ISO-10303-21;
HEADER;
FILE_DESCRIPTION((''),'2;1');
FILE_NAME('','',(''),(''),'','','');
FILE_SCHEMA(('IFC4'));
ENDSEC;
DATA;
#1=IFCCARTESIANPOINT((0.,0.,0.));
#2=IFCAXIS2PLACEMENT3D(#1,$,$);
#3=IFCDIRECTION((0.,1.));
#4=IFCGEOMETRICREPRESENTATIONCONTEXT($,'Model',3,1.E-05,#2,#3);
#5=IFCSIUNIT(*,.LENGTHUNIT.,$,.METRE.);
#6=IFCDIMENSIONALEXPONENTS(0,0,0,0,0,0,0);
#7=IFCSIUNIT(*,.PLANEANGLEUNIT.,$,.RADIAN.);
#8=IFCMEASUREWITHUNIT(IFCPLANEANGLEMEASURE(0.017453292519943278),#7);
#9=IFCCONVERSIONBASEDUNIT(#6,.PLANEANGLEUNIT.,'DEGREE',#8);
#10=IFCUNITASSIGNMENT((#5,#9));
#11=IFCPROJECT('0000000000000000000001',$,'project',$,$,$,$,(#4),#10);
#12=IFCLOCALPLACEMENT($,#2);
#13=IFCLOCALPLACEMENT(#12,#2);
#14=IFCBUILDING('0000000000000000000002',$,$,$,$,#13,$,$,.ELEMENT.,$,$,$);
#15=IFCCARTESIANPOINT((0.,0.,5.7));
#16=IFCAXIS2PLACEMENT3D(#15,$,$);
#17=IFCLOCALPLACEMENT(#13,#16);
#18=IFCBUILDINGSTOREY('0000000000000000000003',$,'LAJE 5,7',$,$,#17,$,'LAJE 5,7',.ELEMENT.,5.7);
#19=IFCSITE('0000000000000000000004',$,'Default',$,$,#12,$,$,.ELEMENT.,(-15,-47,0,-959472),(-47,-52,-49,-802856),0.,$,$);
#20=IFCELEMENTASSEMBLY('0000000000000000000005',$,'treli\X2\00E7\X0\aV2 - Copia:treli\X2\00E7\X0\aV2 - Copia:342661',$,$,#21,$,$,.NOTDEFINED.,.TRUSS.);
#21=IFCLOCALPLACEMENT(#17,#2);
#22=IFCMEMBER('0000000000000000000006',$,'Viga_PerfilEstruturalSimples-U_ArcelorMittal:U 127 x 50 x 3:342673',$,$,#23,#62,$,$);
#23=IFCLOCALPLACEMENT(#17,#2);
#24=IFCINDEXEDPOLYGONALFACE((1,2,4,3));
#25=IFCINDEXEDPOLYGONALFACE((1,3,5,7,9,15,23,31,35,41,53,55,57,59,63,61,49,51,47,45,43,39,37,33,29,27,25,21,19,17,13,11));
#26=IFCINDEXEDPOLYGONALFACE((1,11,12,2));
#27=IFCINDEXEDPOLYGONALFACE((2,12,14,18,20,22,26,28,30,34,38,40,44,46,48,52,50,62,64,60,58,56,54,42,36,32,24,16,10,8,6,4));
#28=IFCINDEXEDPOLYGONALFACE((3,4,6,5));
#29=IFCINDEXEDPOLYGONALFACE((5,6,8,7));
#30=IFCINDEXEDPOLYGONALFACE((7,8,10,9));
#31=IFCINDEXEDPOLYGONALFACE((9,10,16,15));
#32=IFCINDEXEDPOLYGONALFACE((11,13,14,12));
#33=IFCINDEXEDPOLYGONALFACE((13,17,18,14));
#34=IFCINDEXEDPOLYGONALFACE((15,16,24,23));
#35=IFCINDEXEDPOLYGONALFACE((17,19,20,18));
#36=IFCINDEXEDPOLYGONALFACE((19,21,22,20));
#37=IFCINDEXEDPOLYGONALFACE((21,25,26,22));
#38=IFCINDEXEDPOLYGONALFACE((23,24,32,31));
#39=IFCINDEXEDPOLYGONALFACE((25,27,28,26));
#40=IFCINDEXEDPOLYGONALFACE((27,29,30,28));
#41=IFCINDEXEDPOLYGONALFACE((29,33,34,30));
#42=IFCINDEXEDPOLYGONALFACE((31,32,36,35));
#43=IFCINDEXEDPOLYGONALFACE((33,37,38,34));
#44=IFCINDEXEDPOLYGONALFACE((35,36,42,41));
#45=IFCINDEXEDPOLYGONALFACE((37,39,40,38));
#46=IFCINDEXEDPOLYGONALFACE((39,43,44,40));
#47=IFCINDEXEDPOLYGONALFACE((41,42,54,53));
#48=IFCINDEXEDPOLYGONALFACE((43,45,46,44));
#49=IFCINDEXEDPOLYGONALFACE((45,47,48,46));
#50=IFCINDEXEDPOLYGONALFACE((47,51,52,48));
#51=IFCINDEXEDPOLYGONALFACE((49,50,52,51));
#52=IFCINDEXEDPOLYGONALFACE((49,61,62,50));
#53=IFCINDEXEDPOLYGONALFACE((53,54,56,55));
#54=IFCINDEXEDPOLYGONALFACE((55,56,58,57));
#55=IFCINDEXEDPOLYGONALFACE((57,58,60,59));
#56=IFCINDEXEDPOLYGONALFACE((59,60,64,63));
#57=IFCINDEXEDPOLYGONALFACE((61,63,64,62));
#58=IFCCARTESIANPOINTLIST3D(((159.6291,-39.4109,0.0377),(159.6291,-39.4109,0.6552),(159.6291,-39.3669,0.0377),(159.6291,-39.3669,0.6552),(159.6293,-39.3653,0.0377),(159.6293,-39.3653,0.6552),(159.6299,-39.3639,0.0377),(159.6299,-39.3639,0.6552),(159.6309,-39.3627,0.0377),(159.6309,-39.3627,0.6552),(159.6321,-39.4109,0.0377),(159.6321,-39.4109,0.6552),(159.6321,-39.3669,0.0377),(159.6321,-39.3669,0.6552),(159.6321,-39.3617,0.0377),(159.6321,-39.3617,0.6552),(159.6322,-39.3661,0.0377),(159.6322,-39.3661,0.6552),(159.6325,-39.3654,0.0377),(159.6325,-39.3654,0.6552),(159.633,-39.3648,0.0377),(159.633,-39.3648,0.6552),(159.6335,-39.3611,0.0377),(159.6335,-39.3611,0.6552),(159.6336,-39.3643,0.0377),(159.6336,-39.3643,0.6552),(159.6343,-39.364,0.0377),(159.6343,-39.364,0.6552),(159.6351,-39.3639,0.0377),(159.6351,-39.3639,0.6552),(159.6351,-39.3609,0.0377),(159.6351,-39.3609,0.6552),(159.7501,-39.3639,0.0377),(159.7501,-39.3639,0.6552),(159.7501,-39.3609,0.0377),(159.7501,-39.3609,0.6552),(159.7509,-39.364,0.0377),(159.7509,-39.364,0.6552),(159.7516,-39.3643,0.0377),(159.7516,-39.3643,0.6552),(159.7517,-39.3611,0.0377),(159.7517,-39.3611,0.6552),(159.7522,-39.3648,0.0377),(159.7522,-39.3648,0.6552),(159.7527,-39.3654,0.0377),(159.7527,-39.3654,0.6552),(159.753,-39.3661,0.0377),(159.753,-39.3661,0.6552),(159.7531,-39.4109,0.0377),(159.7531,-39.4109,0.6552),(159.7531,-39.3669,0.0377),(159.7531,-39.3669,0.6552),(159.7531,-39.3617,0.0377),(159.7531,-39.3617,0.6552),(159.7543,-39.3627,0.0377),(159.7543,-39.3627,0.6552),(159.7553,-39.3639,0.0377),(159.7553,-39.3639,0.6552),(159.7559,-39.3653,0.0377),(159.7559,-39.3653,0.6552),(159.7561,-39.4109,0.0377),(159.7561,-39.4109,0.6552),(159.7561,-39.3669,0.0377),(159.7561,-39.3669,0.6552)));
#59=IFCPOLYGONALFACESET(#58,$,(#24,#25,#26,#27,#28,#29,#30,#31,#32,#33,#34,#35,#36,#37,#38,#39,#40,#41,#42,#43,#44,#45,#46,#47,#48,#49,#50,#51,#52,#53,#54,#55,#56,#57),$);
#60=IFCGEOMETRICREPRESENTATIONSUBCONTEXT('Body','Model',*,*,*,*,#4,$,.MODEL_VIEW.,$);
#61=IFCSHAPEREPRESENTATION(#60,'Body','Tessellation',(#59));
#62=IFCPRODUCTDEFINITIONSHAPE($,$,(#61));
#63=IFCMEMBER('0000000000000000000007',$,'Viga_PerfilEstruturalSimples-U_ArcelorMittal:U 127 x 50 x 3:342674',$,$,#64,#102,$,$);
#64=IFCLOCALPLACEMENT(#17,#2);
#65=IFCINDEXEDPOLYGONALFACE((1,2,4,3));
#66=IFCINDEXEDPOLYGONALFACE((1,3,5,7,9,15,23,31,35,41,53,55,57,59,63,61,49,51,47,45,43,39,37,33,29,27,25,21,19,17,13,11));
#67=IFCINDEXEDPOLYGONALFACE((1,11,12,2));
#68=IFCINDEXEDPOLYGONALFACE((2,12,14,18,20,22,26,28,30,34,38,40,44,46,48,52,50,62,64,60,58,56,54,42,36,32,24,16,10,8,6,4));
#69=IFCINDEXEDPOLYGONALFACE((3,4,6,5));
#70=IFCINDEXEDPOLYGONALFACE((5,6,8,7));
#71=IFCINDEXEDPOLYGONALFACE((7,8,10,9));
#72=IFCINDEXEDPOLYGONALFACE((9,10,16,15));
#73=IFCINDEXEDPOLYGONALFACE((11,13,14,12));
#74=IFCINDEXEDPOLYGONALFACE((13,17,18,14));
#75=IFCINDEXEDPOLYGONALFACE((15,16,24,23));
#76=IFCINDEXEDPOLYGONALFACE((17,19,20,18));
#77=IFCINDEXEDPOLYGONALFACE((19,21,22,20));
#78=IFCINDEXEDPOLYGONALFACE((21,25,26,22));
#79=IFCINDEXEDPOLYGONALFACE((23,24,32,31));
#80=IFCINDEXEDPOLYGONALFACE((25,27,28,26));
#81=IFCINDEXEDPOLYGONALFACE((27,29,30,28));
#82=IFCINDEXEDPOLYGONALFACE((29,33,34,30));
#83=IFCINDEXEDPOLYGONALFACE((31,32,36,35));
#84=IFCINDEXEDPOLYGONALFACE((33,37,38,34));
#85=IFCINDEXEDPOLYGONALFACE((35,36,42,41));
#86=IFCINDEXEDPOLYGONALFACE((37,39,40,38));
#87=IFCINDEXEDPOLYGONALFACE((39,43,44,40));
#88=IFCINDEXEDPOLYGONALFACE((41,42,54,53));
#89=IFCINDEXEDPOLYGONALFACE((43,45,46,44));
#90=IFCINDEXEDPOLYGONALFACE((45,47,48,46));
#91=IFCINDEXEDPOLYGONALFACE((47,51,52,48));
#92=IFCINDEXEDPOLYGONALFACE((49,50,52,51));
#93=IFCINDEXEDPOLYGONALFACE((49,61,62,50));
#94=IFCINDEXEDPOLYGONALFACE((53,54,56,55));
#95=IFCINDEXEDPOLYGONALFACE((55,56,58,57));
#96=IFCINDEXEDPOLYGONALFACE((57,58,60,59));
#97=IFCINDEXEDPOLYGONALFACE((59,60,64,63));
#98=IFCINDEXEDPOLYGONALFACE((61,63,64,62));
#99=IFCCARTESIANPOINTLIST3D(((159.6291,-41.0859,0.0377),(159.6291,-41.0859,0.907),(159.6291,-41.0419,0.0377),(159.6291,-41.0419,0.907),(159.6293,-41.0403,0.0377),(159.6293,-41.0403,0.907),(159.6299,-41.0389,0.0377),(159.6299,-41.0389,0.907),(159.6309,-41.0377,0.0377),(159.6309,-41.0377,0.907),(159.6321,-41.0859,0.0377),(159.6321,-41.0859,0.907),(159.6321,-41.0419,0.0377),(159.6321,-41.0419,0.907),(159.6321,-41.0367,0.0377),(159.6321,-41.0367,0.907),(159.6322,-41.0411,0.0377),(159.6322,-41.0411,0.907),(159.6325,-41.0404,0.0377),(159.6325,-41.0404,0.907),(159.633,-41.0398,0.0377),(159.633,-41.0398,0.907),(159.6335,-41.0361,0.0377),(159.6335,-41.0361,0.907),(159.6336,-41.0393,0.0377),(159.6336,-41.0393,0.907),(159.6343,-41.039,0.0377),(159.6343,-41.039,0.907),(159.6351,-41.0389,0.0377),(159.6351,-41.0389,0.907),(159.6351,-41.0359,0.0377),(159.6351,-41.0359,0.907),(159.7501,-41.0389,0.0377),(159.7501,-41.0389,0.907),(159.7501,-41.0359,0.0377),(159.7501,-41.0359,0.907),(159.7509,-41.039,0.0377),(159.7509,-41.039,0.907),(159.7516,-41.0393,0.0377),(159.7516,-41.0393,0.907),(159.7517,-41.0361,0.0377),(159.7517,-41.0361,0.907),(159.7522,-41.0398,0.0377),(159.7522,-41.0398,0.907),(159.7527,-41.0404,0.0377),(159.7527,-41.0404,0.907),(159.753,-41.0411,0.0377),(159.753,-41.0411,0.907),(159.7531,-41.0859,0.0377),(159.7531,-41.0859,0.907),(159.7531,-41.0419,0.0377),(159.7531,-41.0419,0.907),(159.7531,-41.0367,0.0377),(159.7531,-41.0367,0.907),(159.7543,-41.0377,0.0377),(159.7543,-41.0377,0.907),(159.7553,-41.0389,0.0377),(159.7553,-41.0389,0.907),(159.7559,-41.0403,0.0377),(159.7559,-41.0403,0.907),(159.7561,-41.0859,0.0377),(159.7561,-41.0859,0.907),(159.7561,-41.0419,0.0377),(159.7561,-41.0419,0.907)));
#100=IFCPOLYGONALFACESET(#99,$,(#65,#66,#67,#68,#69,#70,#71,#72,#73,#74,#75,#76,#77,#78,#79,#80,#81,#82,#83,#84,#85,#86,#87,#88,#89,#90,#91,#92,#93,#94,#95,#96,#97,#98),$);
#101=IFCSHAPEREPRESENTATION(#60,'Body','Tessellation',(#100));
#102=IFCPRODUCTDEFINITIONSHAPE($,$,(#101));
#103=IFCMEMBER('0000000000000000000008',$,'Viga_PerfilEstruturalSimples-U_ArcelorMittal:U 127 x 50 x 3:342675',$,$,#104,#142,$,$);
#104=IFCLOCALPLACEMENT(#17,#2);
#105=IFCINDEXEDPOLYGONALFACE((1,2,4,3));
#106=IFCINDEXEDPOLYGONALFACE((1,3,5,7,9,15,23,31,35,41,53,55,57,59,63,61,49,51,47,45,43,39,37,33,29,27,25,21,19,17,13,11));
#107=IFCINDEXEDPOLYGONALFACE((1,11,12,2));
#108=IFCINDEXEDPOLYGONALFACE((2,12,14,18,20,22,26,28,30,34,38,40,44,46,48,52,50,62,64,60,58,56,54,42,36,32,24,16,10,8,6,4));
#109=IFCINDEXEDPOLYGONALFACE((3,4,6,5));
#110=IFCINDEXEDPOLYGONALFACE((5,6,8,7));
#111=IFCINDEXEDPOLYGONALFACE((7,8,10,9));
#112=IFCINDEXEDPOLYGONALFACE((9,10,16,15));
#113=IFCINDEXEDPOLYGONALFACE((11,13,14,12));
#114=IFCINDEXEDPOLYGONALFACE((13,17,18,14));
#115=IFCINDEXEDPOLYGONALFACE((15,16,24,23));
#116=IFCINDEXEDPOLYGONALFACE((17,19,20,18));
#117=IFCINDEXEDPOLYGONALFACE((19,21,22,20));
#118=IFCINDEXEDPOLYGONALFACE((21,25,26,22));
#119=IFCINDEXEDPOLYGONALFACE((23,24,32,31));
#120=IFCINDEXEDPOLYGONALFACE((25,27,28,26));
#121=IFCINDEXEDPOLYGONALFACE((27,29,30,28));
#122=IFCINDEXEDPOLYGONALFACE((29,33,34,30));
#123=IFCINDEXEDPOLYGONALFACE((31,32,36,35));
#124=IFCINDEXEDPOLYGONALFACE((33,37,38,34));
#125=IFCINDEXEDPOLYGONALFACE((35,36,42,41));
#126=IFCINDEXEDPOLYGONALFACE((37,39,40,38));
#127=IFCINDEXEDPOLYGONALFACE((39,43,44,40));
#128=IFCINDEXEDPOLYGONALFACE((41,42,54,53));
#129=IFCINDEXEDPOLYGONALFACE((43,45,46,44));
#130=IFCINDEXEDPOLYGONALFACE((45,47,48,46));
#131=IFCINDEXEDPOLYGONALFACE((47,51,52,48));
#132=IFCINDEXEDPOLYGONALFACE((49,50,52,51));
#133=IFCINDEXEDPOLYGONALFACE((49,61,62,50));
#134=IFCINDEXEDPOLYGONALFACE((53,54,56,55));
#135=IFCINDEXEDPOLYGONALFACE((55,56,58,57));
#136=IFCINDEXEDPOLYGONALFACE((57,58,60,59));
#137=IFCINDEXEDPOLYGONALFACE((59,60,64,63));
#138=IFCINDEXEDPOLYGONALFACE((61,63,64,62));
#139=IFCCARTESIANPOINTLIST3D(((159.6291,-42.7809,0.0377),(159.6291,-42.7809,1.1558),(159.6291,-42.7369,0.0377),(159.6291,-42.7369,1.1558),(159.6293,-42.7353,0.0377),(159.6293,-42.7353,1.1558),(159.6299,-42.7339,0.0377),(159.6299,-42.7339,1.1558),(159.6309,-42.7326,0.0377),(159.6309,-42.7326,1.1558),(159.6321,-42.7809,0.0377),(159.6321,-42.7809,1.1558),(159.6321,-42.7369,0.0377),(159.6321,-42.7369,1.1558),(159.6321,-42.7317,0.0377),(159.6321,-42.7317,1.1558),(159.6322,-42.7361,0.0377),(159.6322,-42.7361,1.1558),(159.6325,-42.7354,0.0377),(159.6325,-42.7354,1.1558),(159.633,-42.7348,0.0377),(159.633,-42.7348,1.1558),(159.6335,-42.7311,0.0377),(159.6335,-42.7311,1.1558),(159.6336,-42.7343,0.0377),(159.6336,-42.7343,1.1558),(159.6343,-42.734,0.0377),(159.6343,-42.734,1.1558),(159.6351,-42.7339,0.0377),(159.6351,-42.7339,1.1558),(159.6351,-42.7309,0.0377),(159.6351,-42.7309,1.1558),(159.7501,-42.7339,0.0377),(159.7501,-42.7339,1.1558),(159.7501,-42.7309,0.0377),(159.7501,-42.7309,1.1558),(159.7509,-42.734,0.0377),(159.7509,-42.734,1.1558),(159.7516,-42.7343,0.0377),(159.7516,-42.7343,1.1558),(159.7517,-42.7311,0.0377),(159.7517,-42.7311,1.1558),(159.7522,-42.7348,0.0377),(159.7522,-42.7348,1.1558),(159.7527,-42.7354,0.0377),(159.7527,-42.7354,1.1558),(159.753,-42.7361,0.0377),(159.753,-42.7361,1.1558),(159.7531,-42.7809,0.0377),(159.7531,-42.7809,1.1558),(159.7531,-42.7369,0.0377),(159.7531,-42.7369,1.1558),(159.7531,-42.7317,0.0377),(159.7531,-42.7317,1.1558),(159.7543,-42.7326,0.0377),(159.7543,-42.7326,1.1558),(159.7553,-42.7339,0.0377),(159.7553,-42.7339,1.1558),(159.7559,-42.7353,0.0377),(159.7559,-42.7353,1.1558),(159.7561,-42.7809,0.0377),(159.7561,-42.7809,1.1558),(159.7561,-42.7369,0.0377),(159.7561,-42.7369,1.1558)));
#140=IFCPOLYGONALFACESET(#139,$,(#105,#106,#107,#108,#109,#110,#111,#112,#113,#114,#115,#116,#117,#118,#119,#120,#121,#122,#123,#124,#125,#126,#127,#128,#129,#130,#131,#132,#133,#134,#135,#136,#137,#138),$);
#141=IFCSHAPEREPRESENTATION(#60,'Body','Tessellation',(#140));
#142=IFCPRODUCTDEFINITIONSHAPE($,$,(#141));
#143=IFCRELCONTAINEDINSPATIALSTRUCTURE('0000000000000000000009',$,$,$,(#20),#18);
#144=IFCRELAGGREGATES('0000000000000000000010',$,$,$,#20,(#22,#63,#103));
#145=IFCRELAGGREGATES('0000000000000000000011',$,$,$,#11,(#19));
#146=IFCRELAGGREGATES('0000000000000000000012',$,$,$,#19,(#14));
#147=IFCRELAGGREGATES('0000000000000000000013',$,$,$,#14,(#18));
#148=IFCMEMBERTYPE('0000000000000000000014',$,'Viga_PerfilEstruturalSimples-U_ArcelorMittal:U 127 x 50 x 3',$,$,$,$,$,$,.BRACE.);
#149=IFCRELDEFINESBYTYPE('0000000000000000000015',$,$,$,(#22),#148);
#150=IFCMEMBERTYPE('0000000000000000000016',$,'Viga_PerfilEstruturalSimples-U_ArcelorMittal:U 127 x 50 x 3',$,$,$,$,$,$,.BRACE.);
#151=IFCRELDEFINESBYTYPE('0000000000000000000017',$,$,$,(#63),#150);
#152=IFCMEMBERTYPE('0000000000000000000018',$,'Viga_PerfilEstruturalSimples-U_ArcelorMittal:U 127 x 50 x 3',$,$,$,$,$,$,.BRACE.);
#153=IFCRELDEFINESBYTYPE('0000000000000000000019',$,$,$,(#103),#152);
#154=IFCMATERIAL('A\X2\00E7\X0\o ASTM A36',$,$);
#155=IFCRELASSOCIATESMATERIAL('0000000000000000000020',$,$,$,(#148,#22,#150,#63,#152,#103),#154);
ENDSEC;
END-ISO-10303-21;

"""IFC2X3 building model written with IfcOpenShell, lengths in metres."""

from ifc_helpers import new_model, entity, si_unit, converted_unit, direction, frame, frame_2d, origin, place, context, subcontext, project, spatial, polyline, circle_curve, parameter, trimmed, segment, composite_curve, outline, extrude, source, transform, mapped, material, type_object, type_shapes, element, aggregate, save


model = new_model("IFC2X3")

# Units and contexts
model_context = context("Model", 3, precision=1e-05, world=origin(), true_north=direction((0.0, 1.0)))
body_context = subcontext(model_context, "Body", "Model", "MODEL_VIEW")
ifc_project = project(units=[si_unit("LENGTHUNIT", "METRE"), converted_unit("PLANEANGLEUNIT", "DEGREE", entity("IfcPlaneAngleMeasure", 0.017453292519943278), si_unit("PLANEANGLEUNIT", "RADIAN"), dimensions=[0, 0, 0, 0, 0, 0, 0])], contexts=[model_context])

# Site, building, storey
site_placement = place(None, origin())
site = spatial("IfcSite", under=ifc_project, at=site_placement, Name="Default", CompositionType="ELEMENT", RefLatitude=(-15, -47, 0, -959472), RefLongitude=(-47, -52, -49, -802856), RefElevation=0.0)
building_placement = place(site_placement, origin())
building = spatial("IfcBuilding", under=site, at=building_placement, CompositionType="ELEMENT")
storey_placement = place(building_placement, frame((0.0, 0.0, 5.7)))
storey = spatial("IfcBuildingStorey", under=building, at=storey_placement, Name="LAJE 5,7", LongName="LAJE 5,7", CompositionType="ELEMENT", Elevation=5.7)

# Element assembly
ifc_material = material(Name="Aço ASTM A36")
assembly_1_placement = place(storey_placement, origin())
assembly_1 = element("IfcElementAssembly", 1, at=assembly_1_placement, inside=storey, Name="treliçaV2 - Copia:treliçaV2 - Copia:342661", AssemblyPlace="NOTDEFINED", PredefinedType="TRUSS")

# Members
member_type_1 = type_object("IfcMemberType", Name="Viga_PerfilEstruturalSimples-U_ArcelorMittal:U 127 x 50 x 3", PredefinedType="BRACE", material=ifc_material)
shared_shape_1 = source(origin(), body_context, "Body", "SweptSolid", [
    extrude(outline(composite_curve([segment(polyline([(-0.0575, -0.0192), (0.0575, -0.0192)]), True, "CONTINUOUS"), segment(trimmed(circle_curve(frame_2d((0.0575, -0.0132), x_axis=(0.0, 1.0)), 0.006), [parameter(180.0)], [parameter(270.0)], True, "PARAMETER"), True, "CONTINUOUS"), segment(polyline([(0.0635, -0.0132), (0.0635, 0.0308)]), True, "CONTINUOUS"), segment(polyline([(0.0635, 0.0308), (0.0605, 0.0308)]), True, "CONTINUOUS"), segment(polyline([(0.0605, 0.0308), (0.0605, -0.0132)]), True, "CONTINUOUS"), segment(trimmed(circle_curve(frame_2d((0.0575, -0.0132), x_axis=(0.0, 1.0)), 0.003), [parameter(180.0)], [parameter(270.0)], True, "PARAMETER"), False, "CONTINUOUS"), segment(polyline([(0.0575, -0.0162), (-0.0575, -0.0162)]), True, "CONTINUOUS"), segment(trimmed(circle_curve(frame_2d((-0.0575, -0.0132), x_axis=(0.0, 1.0)), 0.003), [parameter(90.0)], [parameter(180.0)], True, "PARAMETER"), False, "CONTINUOUS"), segment(polyline([(-0.0605, -0.0132), (-0.0605, 0.0308)]), True, "CONTINUOUS"), segment(polyline([(-0.0605, 0.0308), (-0.0635, 0.0308)]), True, "CONTINUOUS"), segment(polyline([(-0.0635, 0.0308), (-0.0635, -0.0132)]), True, "CONTINUOUS"), segment(trimmed(circle_curve(frame_2d((-0.0575, -0.0132), x_axis=(0.0, 1.0)), 0.006), [parameter(90.0)], [parameter(180.0)], True, "PARAMETER"), True, "CONTINUOUS")], self_intersect=False)), frame((-0.3108, -0.0058, 0.0), z_axis=(1.0, 0.0, 0.0), x_axis=(0.0, 0.0, -1.0)), (0.0, 0.0, 1.0), 0.6175),
])
type_shapes(member_type_1, [shared_shape_1])
member_1_placement = place(assembly_1_placement, frame((159.6926, -39.3859, 0.3485), z_axis=(1.0, 0.0, 0.0), x_axis=(0.0, 0.0, 1.0)))
member_1 = element("IfcMember", 2, at=member_1_placement, type_object=member_type_1, material=ifc_material, Name="Viga_PerfilEstruturalSimples-U_ArcelorMittal:U 127 x 50 x 3:342673", context=body_context, shape_type="MappedRepresentation", body=[
    mapped(shared_shape_1, transform((0.0, 0.0, 0.0), scale=1.0)),
])
member_type_2 = type_object("IfcMemberType", Name="Viga_PerfilEstruturalSimples-U_ArcelorMittal:U 127 x 50 x 3", PredefinedType="BRACE", material=ifc_material)
shared_shape_2 = source(origin(), body_context, "Body", "SweptSolid", [
    extrude(outline(composite_curve([segment(polyline([(-0.0575, -0.0192), (0.0575, -0.0192)]), True, "CONTINUOUS"), segment(trimmed(circle_curve(frame_2d((0.0575, -0.0132), x_axis=(0.0, 1.0)), 0.006), [parameter(180.0)], [parameter(270.0)], True, "PARAMETER"), True, "CONTINUOUS"), segment(polyline([(0.0635, -0.0132), (0.0635, 0.0308)]), True, "CONTINUOUS"), segment(polyline([(0.0635, 0.0308), (0.0605, 0.0308)]), True, "CONTINUOUS"), segment(polyline([(0.0605, 0.0308), (0.0605, -0.0132)]), True, "CONTINUOUS"), segment(trimmed(circle_curve(frame_2d((0.0575, -0.0132), x_axis=(0.0, 1.0)), 0.003), [parameter(180.0)], [parameter(270.0)], True, "PARAMETER"), False, "CONTINUOUS"), segment(polyline([(0.0575, -0.0162), (-0.0575, -0.0162)]), True, "CONTINUOUS"), segment(trimmed(circle_curve(frame_2d((-0.0575, -0.0132), x_axis=(0.0, 1.0)), 0.003), [parameter(90.0)], [parameter(180.0)], True, "PARAMETER"), False, "CONTINUOUS"), segment(polyline([(-0.0605, -0.0132), (-0.0605, 0.0308)]), True, "CONTINUOUS"), segment(polyline([(-0.0605, 0.0308), (-0.0635, 0.0308)]), True, "CONTINUOUS"), segment(polyline([(-0.0635, 0.0308), (-0.0635, -0.0132)]), True, "CONTINUOUS"), segment(trimmed(circle_curve(frame_2d((-0.0575, -0.0132), x_axis=(0.0, 1.0)), 0.006), [parameter(90.0)], [parameter(180.0)], True, "PARAMETER"), True, "CONTINUOUS")], self_intersect=False)), frame((-0.4367, -0.0058, 0.0), z_axis=(1.0, 0.0, 0.0), x_axis=(0.0, 0.0, -1.0)), (0.0, 0.0, 1.0), 0.8693),
])
type_shapes(member_type_2, [shared_shape_2])
member_2_placement = place(assembly_1_placement, frame((159.6926, -41.0609, 0.4744), z_axis=(1.0, 0.0, 0.0), x_axis=(0.0, 0.0, 1.0)))
member_2 = element("IfcMember", 3, at=member_2_placement, type_object=member_type_2, material=ifc_material, Name="Viga_PerfilEstruturalSimples-U_ArcelorMittal:U 127 x 50 x 3:342674", context=body_context, shape_type="MappedRepresentation", body=[
    mapped(shared_shape_2, transform((0.0, 0.0, 0.0), scale=1.0)),
])
member_type_3 = type_object("IfcMemberType", Name="Viga_PerfilEstruturalSimples-U_ArcelorMittal:U 127 x 50 x 3", PredefinedType="BRACE", material=ifc_material)
shared_shape_3 = source(origin(), body_context, "Body", "SweptSolid", [
    extrude(outline(composite_curve([segment(polyline([(-0.0575, -0.0192), (0.0575, -0.0192)]), True, "CONTINUOUS"), segment(trimmed(circle_curve(frame_2d((0.0575, -0.0132), x_axis=(0.0, 1.0)), 0.006), [parameter(180.0)], [parameter(270.0)], True, "PARAMETER"), True, "CONTINUOUS"), segment(polyline([(0.0635, -0.0132), (0.0635, 0.0308)]), True, "CONTINUOUS"), segment(polyline([(0.0635, 0.0308), (0.0605, 0.0308)]), True, "CONTINUOUS"), segment(polyline([(0.0605, 0.0308), (0.0605, -0.0132)]), True, "CONTINUOUS"), segment(trimmed(circle_curve(frame_2d((0.0575, -0.0132), x_axis=(0.0, 1.0)), 0.003), [parameter(180.0)], [parameter(270.0)], True, "PARAMETER"), False, "CONTINUOUS"), segment(polyline([(0.0575, -0.0162), (-0.0575, -0.0162)]), True, "CONTINUOUS"), segment(trimmed(circle_curve(frame_2d((-0.0575, -0.0132), x_axis=(0.0, 1.0)), 0.003), [parameter(90.0)], [parameter(180.0)], True, "PARAMETER"), False, "CONTINUOUS"), segment(polyline([(-0.0605, -0.0132), (-0.0605, 0.0308)]), True, "CONTINUOUS"), segment(polyline([(-0.0605, 0.0308), (-0.0635, 0.0308)]), True, "CONTINUOUS"), segment(polyline([(-0.0635, 0.0308), (-0.0635, -0.0132)]), True, "CONTINUOUS"), segment(trimmed(circle_curve(frame_2d((-0.0575, -0.0132), x_axis=(0.0, 1.0)), 0.006), [parameter(90.0)], [parameter(180.0)], True, "PARAMETER"), True, "CONTINUOUS")], self_intersect=False)), frame((-0.5611, -0.0058, 0.0), z_axis=(1.0, 0.0, 0.0), x_axis=(0.0, 0.0, -1.0)), (0.0, 0.0, 1.0), 1.1181),
])
type_shapes(member_type_3, [shared_shape_3])
member_3_placement = place(assembly_1_placement, frame((159.6926, -42.7559, 0.5988), z_axis=(1.0, 0.0, 0.0), x_axis=(0.0, 0.0, 1.0)))
member_3 = element("IfcMember", 4, at=member_3_placement, type_object=member_type_3, material=ifc_material, Name="Viga_PerfilEstruturalSimples-U_ArcelorMittal:U 127 x 50 x 3:342675", context=body_context, shape_type="MappedRepresentation", body=[
    mapped(shared_shape_3, transform((0.0, 0.0, 0.0), scale=1.0)),
])
aggregate(assembly_1, [member_1, member_2, member_3])

save(model, "model.ifc")
